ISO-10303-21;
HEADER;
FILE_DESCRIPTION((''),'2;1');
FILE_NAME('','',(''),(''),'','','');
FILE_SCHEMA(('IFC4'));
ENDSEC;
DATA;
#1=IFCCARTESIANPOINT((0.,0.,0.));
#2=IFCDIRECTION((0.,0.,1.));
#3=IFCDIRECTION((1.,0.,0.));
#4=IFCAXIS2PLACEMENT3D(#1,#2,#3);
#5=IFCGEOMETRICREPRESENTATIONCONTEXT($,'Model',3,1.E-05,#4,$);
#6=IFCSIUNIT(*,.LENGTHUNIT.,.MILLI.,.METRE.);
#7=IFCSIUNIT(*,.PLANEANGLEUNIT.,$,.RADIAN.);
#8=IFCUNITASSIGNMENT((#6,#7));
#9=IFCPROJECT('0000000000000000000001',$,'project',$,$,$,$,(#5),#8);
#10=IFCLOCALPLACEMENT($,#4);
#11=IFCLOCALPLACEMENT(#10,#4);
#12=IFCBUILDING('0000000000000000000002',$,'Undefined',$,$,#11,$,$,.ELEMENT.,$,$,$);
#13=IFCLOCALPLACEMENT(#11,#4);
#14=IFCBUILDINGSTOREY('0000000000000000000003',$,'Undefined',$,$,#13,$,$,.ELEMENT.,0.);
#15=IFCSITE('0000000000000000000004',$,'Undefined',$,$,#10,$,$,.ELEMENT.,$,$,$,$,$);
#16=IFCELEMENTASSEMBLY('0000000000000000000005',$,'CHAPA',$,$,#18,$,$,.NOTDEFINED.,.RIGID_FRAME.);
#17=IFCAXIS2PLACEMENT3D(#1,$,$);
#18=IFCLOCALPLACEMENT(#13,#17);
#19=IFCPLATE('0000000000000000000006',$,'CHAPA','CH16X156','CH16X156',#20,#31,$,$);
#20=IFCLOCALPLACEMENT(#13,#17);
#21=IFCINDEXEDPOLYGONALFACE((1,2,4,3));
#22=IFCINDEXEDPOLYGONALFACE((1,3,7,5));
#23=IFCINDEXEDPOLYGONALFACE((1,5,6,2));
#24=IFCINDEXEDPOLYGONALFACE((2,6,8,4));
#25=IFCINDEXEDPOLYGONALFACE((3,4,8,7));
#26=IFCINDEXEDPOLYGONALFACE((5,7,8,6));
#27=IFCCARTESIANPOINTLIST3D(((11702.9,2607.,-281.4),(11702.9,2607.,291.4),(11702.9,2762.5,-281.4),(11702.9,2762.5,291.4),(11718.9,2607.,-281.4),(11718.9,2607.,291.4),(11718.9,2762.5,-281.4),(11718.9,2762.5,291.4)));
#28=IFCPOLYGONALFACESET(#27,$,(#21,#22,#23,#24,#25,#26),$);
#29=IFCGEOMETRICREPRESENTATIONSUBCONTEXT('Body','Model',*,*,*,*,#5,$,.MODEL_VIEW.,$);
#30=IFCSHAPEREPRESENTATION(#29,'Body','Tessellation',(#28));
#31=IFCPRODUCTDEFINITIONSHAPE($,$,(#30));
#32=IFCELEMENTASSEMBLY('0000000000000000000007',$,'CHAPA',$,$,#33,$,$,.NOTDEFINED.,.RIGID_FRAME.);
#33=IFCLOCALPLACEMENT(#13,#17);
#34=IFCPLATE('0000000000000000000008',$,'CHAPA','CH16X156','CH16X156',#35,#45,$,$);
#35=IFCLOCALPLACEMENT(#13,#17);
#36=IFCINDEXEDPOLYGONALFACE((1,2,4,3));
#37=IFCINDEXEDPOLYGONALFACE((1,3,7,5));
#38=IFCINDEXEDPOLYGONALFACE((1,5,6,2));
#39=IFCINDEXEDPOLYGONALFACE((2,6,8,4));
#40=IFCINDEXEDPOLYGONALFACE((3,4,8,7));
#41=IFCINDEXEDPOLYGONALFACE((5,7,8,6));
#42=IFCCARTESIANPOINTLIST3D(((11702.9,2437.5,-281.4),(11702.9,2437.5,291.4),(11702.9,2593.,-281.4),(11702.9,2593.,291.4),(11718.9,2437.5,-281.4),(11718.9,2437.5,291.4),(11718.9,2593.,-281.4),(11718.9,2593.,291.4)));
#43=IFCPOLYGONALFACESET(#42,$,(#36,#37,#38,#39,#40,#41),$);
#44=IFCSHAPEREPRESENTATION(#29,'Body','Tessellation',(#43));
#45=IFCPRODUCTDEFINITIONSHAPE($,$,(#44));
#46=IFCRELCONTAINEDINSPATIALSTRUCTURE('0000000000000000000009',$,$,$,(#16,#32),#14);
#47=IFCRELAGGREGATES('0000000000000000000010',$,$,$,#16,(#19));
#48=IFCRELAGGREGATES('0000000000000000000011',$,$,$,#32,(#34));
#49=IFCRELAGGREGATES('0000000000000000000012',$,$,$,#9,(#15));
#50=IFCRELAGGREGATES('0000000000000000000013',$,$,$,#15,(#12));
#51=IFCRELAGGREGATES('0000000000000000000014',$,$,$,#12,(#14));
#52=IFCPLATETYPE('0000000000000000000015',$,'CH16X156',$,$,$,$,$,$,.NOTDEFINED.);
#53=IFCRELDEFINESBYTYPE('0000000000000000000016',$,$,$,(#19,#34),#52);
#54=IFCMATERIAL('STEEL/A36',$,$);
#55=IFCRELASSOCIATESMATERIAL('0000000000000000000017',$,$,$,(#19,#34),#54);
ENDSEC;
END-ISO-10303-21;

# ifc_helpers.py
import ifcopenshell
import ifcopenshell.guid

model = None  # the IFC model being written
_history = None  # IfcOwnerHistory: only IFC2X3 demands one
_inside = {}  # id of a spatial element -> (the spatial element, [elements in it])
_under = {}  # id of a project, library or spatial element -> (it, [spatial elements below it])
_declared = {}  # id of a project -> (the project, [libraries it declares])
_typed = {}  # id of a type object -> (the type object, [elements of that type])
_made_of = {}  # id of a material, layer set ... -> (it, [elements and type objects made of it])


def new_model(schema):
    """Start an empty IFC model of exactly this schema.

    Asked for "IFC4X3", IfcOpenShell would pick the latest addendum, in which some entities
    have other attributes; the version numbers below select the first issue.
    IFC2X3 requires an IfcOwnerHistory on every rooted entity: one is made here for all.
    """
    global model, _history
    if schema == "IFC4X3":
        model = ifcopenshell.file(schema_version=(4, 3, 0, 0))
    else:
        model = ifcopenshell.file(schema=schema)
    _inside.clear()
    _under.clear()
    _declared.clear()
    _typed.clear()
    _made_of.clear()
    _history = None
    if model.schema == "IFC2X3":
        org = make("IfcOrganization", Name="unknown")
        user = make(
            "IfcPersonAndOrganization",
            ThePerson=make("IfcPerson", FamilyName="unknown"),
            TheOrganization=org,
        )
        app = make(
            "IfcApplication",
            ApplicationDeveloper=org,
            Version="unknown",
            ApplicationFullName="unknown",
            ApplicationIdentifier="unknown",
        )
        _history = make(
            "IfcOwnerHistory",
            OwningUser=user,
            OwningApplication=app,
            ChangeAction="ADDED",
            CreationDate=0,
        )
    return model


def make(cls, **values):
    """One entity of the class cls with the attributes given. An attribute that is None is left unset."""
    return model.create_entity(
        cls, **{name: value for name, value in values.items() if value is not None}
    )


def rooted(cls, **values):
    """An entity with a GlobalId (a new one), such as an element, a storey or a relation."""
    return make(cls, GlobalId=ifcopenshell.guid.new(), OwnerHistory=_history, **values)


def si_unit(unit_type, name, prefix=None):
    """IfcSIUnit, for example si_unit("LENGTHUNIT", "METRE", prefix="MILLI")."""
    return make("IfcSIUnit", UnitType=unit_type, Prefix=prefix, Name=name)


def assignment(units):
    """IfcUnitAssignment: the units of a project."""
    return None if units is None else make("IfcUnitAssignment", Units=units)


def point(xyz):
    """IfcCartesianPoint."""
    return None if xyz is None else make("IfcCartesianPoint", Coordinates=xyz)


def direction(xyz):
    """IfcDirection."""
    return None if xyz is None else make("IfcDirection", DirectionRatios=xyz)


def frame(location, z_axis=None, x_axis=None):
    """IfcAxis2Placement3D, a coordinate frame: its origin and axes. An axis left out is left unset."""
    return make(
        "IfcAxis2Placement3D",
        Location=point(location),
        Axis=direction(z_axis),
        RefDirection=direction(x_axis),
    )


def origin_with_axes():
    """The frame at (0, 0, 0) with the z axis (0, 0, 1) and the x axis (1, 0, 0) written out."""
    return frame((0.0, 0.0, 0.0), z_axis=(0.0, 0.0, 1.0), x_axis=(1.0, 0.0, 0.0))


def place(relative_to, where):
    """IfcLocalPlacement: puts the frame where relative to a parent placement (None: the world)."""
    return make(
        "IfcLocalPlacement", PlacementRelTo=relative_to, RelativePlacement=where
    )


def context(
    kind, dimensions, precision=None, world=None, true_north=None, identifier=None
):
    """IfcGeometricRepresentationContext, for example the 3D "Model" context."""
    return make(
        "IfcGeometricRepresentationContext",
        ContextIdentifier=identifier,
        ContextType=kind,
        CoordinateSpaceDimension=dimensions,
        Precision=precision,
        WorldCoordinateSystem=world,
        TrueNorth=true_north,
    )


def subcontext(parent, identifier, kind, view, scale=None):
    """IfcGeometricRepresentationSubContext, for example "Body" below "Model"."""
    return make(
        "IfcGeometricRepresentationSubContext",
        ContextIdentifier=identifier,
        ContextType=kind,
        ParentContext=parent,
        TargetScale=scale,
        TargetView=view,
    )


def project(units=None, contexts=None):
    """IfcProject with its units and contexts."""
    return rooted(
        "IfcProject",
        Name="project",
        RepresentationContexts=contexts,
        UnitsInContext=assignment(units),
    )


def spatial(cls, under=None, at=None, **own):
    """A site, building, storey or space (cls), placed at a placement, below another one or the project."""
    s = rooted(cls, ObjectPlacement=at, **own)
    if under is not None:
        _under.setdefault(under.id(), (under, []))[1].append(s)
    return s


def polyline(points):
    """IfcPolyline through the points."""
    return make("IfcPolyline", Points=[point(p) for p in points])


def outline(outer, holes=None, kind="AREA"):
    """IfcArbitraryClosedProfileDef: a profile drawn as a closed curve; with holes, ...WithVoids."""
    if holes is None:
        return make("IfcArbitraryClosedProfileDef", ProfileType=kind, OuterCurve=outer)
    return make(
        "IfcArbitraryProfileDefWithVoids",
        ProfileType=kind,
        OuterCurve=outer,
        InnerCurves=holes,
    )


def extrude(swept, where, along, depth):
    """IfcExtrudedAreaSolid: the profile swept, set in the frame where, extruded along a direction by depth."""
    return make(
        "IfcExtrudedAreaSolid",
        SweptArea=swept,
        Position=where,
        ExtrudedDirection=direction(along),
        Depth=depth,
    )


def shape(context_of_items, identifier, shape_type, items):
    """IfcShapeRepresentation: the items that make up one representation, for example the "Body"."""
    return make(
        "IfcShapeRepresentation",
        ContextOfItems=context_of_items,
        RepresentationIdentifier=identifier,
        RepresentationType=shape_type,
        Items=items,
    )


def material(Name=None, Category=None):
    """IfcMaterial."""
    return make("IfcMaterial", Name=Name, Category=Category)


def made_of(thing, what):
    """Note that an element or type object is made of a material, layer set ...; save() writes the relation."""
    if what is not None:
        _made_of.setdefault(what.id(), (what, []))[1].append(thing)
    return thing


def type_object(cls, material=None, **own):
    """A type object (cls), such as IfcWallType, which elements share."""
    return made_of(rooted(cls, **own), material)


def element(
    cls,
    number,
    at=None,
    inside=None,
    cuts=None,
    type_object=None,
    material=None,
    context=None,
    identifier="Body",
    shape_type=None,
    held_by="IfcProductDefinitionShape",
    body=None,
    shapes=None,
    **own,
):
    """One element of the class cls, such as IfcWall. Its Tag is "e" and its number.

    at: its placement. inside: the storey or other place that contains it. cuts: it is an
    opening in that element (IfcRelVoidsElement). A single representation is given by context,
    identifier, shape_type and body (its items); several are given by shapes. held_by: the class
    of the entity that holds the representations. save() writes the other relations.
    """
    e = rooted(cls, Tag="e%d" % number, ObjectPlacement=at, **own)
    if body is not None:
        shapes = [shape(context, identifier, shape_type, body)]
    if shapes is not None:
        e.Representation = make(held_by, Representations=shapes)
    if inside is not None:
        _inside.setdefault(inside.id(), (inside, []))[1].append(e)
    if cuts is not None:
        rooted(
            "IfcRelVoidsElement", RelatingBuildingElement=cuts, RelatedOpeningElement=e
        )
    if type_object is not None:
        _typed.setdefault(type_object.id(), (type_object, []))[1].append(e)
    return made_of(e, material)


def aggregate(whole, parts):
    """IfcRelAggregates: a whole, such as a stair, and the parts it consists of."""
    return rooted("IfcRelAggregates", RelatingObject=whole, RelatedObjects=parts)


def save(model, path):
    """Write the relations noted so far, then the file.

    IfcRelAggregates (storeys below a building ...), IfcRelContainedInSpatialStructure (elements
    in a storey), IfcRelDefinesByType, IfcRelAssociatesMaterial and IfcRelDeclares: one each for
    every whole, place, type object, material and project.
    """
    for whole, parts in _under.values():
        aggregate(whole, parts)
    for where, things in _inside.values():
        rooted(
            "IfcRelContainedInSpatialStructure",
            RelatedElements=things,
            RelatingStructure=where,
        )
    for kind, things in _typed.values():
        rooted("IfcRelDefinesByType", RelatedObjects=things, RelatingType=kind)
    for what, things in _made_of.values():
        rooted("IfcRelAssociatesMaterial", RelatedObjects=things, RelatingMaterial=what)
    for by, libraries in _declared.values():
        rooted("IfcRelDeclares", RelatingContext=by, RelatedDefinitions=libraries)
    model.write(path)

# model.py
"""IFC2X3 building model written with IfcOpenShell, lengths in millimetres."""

from ifc_helpers import new_model, si_unit, frame, origin_with_axes, place, context, subcontext, project, spatial, polyline, outline, extrude, material, type_object, element, aggregate, save


model = new_model("IFC2X3")

# Units and contexts
model_context = context("Model", 3, precision=1e-05, world=origin_with_axes())
body_context = subcontext(model_context, "Body", "Model", "MODEL_VIEW")
ifc_project = project(units=[si_unit("LENGTHUNIT", "METRE", prefix="MILLI"), si_unit("PLANEANGLEUNIT", "RADIAN")], contexts=[model_context])

# Site, building, storey
site_placement = place(None, origin_with_axes())
site = spatial("IfcSite", under=ifc_project, at=site_placement, Name="Undefined", CompositionType="ELEMENT")
building_placement = place(site_placement, origin_with_axes())
building = spatial("IfcBuilding", under=site, at=building_placement, Name="Undefined", CompositionType="ELEMENT")
storey_placement = place(building_placement, origin_with_axes())
storey = spatial("IfcBuildingStorey", under=building, at=storey_placement, Name="Undefined", CompositionType="ELEMENT", Elevation=0.0)

# Element assemblies, plates
ifc_material_1 = material(Name="STEEL/A36")
plate_type = type_object("IfcPlateType", Name="CH16X156", PredefinedType="NOTDEFINED")
assembly_1_placement = place(storey_placement, origin_with_axes())
assembly_1 = element("IfcElementAssembly", 1, at=assembly_1_placement, inside=storey, Name="CHAPA", AssemblyPlace="NOTDEFINED", PredefinedType="RIGID_FRAME")
plate_1_placement = place(assembly_1_placement, frame((11710.9, 2762.5, 291.4), z_axis=(1.0, 0.0, 0.0), x_axis=(0.0, -1.0, 0.0)))
plate_1 = element("IfcPlate", 2, at=plate_1_placement, type_object=plate_type, material=ifc_material_1, Name="CHAPA", Description="CH16X156", ObjectType="CH16X156", context=body_context, shape_type="SweptSolid", body=[
    extrude(outline(polyline([(0.0, 0.0), (155.5, 0.0), (155.5, 572.8), (0.0, 572.8), (0.0, 0.0)])), frame((0.0, 0.0, -8.0), z_axis=(0.0, 0.0, 1.0), x_axis=(1.0, 0.0, 0.0)), (0.0, 0.0, 1.0), 16.0),
])
aggregate(assembly_1, [plate_1])
assembly_2_placement = place(storey_placement, origin_with_axes())
assembly_2 = element("IfcElementAssembly", 3, at=assembly_2_placement, inside=storey, Name="CHAPA", AssemblyPlace="NOTDEFINED", PredefinedType="RIGID_FRAME")
plate_2_placement = place(assembly_2_placement, frame((11710.9, 2593.0, 291.4), z_axis=(1.0, 0.0, 0.0), x_axis=(0.0, -1.0, 0.0)))
plate_2 = element("IfcPlate", 4, at=plate_2_placement, type_object=plate_type, material=ifc_material_1, Name="CHAPA", Description="CH16X156", ObjectType="CH16X156", context=body_context, shape_type="SweptSolid", body=[
    extrude(outline(polyline([(0.0, 0.0), (155.5, 0.0), (155.5, 572.8), (0.0, 572.8), (0.0, 0.0)])), frame((0.0, 0.0, -8.0), z_axis=(0.0, 0.0, 1.0), x_axis=(1.0, 0.0, 0.0)), (0.0, 0.0, 1.0), 16.0),
])
aggregate(assembly_2, [plate_2])

save(model, "model.ifc")
